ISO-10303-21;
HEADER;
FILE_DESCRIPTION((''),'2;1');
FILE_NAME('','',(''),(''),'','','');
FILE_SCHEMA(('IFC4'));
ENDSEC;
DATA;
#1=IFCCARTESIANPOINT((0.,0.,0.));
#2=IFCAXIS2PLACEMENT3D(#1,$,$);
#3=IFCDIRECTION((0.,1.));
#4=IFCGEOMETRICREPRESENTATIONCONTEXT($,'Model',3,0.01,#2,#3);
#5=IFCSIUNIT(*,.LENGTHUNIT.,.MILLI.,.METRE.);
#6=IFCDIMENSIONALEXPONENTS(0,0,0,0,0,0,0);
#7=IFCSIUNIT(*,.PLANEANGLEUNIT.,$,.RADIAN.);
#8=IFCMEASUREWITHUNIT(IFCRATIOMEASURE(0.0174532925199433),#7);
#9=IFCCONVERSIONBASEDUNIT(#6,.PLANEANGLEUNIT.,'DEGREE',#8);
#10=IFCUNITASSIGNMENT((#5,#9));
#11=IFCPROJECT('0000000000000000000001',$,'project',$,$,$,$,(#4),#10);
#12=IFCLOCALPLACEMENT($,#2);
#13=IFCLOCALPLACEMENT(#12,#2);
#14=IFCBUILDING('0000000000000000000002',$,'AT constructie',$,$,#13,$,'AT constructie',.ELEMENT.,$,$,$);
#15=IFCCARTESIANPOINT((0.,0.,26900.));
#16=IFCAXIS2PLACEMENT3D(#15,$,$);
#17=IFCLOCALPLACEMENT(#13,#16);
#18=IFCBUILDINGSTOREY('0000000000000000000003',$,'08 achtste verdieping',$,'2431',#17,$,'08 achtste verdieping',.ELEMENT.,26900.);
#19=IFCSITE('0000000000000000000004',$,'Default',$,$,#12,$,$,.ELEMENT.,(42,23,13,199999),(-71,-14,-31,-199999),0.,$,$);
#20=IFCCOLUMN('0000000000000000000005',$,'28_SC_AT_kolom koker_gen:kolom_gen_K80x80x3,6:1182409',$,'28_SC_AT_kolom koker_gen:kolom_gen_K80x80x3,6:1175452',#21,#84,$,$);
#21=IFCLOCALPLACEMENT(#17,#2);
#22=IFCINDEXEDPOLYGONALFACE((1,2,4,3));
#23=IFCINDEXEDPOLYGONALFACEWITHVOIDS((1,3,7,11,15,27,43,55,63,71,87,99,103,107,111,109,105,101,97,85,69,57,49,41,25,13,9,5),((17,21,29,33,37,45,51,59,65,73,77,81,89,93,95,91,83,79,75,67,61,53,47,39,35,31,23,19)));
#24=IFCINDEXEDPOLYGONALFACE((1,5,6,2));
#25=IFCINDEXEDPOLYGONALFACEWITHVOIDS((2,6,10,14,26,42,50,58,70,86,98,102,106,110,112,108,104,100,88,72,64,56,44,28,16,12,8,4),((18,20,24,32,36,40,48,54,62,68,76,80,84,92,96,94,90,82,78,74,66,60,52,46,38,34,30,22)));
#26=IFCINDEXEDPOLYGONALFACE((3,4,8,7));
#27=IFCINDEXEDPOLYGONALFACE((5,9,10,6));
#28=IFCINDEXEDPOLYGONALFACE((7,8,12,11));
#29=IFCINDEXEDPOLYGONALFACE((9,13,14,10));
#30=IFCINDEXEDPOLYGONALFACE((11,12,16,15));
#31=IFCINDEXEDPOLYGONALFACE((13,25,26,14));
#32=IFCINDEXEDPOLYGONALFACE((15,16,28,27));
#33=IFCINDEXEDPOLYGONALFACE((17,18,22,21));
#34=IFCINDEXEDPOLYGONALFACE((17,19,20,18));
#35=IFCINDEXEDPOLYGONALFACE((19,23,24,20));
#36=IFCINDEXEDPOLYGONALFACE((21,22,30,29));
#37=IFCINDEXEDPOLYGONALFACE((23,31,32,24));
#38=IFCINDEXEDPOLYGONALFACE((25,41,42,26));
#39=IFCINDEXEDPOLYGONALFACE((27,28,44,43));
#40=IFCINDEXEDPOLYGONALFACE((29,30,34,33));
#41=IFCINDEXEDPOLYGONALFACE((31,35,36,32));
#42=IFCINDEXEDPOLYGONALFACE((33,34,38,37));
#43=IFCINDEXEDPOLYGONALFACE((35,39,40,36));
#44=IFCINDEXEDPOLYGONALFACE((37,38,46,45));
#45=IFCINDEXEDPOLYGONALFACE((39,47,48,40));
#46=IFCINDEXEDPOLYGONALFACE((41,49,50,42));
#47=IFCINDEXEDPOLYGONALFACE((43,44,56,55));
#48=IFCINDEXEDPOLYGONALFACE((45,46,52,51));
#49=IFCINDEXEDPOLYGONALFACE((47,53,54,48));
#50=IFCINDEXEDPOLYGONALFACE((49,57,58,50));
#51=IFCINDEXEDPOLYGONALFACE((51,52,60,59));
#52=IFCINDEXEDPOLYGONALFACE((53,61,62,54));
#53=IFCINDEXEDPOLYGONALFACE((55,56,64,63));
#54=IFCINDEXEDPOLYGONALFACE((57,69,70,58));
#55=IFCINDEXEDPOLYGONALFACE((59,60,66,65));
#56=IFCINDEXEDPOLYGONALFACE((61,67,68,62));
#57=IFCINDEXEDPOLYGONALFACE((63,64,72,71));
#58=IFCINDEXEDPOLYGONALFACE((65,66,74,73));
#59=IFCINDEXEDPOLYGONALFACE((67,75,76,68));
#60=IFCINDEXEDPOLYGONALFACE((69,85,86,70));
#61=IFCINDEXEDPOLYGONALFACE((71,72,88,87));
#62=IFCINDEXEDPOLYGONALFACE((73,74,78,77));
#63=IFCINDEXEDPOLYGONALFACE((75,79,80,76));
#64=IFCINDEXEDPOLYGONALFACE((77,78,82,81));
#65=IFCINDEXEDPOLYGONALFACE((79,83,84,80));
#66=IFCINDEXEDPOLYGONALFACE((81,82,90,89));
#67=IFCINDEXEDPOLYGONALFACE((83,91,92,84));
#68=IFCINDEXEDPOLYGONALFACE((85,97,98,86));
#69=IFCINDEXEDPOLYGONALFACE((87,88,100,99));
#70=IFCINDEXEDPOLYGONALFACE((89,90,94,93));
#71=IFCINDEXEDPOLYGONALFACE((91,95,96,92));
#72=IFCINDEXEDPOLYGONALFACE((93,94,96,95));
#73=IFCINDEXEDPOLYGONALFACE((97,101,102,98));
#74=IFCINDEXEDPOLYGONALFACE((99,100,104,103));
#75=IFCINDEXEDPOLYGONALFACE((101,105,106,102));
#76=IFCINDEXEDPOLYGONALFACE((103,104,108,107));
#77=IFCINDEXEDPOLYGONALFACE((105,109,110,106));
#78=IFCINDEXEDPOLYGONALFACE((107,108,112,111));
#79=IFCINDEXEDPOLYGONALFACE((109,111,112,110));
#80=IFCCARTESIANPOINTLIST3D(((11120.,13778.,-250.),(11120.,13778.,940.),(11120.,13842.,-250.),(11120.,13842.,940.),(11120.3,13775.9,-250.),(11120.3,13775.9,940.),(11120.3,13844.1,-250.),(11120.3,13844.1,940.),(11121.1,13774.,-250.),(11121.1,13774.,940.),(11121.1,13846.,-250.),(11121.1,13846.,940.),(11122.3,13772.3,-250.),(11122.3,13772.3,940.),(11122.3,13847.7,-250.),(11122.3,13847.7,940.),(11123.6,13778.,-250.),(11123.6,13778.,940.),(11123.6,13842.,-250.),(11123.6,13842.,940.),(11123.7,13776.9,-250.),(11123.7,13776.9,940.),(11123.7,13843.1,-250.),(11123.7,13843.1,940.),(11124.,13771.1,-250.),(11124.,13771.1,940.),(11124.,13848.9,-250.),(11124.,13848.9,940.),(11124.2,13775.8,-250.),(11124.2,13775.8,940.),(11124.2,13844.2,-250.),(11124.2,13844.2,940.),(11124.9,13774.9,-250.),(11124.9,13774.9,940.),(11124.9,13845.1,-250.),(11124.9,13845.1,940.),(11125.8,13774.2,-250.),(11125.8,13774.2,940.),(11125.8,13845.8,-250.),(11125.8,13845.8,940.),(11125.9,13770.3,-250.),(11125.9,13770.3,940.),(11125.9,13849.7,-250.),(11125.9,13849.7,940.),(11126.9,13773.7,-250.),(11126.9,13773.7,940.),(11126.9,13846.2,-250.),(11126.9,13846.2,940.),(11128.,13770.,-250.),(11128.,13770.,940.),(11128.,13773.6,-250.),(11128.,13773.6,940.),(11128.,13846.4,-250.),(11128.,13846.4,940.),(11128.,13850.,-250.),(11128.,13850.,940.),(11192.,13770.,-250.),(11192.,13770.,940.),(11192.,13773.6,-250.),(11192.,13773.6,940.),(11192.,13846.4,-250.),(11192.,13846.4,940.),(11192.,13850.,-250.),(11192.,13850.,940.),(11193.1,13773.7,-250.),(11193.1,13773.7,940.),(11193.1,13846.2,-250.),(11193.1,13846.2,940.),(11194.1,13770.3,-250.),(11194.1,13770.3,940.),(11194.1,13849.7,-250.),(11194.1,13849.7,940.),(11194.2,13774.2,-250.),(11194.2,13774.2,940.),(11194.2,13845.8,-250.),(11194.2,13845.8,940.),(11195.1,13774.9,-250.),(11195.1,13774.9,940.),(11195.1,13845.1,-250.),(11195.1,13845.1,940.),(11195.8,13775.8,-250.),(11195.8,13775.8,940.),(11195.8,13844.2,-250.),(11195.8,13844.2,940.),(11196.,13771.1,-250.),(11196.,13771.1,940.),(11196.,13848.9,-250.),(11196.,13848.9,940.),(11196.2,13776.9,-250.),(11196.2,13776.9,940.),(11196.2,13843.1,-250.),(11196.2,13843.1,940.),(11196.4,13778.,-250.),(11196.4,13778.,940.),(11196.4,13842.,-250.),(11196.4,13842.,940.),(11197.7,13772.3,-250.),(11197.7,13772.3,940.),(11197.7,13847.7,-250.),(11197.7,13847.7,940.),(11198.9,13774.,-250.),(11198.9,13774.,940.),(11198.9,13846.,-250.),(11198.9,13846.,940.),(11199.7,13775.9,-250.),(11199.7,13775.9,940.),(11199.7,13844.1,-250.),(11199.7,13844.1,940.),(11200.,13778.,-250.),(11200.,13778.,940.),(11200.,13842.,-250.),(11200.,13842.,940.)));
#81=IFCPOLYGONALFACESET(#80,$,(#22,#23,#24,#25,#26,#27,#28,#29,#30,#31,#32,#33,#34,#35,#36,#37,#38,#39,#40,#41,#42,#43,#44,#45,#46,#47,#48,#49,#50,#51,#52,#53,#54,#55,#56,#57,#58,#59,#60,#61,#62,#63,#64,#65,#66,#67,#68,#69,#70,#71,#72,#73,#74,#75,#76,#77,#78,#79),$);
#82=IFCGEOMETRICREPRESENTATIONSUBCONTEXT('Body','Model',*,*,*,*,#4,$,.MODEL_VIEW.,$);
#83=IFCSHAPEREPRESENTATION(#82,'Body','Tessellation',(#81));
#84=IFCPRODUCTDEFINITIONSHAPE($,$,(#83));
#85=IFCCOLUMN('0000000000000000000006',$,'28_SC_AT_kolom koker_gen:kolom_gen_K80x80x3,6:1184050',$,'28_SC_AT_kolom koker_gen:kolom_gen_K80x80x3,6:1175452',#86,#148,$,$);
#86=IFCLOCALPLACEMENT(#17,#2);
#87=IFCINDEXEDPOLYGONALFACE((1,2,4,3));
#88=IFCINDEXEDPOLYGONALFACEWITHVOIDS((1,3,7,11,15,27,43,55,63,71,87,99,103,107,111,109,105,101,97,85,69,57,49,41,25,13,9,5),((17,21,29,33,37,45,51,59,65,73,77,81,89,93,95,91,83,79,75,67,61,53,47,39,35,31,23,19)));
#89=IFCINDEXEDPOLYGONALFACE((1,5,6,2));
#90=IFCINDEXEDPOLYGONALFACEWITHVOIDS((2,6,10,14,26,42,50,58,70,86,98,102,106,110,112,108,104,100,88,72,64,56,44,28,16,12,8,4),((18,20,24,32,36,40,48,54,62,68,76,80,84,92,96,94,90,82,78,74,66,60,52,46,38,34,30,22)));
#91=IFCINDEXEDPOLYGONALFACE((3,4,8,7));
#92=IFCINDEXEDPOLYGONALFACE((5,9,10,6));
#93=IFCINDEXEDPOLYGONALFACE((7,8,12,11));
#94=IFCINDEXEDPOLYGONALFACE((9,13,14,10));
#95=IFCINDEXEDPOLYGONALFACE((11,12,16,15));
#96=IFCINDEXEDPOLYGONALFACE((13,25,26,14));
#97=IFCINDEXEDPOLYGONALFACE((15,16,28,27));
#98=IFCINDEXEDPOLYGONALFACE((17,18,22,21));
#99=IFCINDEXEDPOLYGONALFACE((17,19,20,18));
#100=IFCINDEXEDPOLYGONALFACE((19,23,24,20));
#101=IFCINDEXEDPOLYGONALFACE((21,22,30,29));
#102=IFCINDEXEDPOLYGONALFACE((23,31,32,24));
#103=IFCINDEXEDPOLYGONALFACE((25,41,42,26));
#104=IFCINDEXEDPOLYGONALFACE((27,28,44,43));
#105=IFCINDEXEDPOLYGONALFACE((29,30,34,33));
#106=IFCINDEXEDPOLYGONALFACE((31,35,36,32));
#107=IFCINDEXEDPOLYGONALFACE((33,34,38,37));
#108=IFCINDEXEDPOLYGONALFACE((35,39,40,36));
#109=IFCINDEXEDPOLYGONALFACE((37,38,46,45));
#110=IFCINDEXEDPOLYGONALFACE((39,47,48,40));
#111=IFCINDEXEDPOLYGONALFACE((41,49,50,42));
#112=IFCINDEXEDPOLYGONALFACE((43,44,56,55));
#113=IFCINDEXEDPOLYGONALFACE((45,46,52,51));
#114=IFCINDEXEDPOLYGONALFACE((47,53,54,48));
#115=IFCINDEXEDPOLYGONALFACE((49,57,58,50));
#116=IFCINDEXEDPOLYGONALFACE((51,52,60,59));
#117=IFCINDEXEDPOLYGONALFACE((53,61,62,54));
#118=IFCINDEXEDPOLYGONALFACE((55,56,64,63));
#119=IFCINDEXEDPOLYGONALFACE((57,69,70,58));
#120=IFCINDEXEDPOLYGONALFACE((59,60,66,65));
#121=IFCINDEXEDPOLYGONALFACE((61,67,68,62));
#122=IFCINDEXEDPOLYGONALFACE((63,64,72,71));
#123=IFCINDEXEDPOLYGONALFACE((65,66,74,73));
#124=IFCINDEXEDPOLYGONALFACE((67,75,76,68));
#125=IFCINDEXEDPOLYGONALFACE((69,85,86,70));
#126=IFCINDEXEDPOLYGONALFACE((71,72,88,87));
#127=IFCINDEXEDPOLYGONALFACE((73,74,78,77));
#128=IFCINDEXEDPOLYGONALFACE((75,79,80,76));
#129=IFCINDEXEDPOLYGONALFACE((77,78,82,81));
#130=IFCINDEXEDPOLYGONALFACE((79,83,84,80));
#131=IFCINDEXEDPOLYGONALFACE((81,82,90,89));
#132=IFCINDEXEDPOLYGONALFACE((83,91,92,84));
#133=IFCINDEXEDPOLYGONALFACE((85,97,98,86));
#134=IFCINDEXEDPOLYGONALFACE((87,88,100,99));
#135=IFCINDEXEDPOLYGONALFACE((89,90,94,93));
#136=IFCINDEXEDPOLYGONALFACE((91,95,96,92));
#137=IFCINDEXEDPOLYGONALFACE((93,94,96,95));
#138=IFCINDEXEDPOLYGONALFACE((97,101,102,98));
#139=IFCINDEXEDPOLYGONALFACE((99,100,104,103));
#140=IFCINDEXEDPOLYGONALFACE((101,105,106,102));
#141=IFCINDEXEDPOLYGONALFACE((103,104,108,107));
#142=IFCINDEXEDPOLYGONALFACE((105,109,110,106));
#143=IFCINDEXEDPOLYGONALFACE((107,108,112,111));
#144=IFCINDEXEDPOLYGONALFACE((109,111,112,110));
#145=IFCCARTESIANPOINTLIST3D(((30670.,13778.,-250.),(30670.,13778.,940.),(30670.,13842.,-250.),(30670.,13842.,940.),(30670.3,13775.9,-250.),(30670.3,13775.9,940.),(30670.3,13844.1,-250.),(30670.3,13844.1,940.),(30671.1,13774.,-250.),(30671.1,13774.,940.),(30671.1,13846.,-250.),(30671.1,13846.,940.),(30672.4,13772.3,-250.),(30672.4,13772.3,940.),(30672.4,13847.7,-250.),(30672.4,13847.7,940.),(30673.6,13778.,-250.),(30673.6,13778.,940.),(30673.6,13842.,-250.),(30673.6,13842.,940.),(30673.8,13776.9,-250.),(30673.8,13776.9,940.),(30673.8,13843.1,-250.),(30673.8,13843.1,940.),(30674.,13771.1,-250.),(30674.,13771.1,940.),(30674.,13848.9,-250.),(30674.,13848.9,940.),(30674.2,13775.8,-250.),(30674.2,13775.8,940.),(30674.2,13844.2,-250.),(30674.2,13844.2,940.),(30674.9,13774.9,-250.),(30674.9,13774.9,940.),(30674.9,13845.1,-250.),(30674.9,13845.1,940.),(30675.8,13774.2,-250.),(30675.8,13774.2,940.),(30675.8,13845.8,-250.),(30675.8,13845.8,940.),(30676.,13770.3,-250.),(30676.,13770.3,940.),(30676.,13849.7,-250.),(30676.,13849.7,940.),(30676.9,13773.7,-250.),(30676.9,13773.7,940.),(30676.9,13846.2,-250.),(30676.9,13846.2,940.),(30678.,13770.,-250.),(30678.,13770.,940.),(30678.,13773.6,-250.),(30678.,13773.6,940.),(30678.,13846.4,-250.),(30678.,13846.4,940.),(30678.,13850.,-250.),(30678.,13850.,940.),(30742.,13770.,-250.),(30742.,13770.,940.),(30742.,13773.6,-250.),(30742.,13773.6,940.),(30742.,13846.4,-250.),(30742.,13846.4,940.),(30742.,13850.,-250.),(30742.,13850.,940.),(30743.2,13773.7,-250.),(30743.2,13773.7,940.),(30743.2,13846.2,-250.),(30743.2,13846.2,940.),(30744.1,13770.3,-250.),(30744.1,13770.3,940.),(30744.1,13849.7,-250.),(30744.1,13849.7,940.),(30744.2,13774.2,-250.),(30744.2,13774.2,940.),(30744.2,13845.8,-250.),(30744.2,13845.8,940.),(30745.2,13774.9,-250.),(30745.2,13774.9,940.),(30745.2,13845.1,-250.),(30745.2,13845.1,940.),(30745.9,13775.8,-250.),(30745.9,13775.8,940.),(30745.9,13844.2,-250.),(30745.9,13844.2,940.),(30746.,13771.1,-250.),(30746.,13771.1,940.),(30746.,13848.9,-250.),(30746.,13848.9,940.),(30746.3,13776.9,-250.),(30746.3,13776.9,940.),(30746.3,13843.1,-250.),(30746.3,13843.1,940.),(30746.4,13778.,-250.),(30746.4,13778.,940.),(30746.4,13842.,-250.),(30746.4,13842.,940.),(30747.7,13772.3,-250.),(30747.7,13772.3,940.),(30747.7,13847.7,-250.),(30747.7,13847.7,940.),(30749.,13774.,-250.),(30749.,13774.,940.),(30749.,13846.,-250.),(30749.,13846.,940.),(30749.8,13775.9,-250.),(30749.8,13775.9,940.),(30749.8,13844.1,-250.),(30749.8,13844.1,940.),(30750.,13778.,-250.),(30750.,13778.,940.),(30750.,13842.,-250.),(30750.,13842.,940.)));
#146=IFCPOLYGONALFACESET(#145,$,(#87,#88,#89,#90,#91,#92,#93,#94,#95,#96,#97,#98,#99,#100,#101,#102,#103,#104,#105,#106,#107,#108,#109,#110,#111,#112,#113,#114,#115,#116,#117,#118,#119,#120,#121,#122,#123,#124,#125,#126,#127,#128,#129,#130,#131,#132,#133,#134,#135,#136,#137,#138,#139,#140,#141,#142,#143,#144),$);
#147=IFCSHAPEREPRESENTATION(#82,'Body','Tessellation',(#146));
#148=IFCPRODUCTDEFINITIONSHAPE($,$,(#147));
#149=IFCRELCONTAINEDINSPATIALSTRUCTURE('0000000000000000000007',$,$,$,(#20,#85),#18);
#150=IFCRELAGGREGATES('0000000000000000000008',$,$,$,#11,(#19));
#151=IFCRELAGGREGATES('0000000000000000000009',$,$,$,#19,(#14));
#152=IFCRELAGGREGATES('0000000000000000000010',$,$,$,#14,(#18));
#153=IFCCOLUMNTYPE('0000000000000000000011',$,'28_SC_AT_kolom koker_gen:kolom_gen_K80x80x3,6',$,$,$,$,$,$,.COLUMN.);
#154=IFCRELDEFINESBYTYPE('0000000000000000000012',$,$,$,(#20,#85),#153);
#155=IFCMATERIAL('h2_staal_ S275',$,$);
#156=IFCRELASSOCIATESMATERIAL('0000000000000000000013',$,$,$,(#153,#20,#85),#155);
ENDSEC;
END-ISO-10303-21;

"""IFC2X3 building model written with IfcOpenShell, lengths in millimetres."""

from ifc_helpers import new_model, entity, si_unit, converted_unit, direction, frame, frame_2d, origin, place, context, subcontext, project, spatial, polyline, circle_curve, parameter, trimmed, segment, composite_curve, outline, extrude, source, transform, mapped, material, type_object, type_shapes, element, save


model = new_model("IFC2X3")

# Units and contexts
model_context = context("Model", 3, precision=0.01, world=origin(), true_north=direction((0.0, 1.0)))
body_context = subcontext(model_context, "Body", "Model", "MODEL_VIEW")
ifc_project = project(units=[si_unit("LENGTHUNIT", "METRE", prefix="MILLI"), converted_unit("PLANEANGLEUNIT", "DEGREE", entity("IfcRatioMeasure", 0.0174532925199433), si_unit("PLANEANGLEUNIT", "RADIAN"), dimensions=[0, 0, 0, 0, 0, 0, 0])], contexts=[model_context])

# Site, building, storey
site_placement = place(None, origin())
site = spatial("IfcSite", under=ifc_project, at=site_placement, Name="Default", CompositionType="ELEMENT", RefLatitude=(42, 23, 13, 199999), RefLongitude=(-71, -14, -31, -199999), RefElevation=0.0)
building_placement = place(site_placement, origin())
building = spatial("IfcBuilding", under=site, at=building_placement, Name="AT constructie", LongName="AT constructie", CompositionType="ELEMENT")
storey_placement = place(building_placement, frame((0.0, 0.0, 26900.0)))
storey = spatial("IfcBuildingStorey", under=building, at=storey_placement, Name="08 achtste verdieping", ObjectType="2431", LongName="08 achtste verdieping", CompositionType="ELEMENT", Elevation=26900.0)

# Columns
ifc_material_1 = material(Name="h2_staal_ S275")
column_type_1 = type_object("IfcColumnType", Name="28_SC_AT_kolom koker_gen:kolom_gen_K80x80x3,6", PredefinedType="COLUMN", material=ifc_material_1)
shared_shape_1 = source(origin(), body_context, "Body", "SweptSolid", [
    extrude(outline(composite_curve([segment(trimmed(circle_curve(frame_2d((32.0, 32.0), x_axis=(1.0, 0.0)), 8.0), [parameter(360.0)], [parameter(90.0)], True, "PARAMETER"), True, "CONTINUOUS"), segment(polyline([(32.0, 40.0), (-32.0, 40.0)]), True, "CONTINUOUS"), segment(trimmed(circle_curve(frame_2d((-32.0, 32.0), x_axis=(1.0, 0.0)), 8.0), [parameter(90.0)], [parameter(180.0)], True, "PARAMETER"), True, "CONTINUOUS"), segment(polyline([(-40.0, 32.0), (-40.0, -32.0)]), True, "CONTINUOUS"), segment(trimmed(circle_curve(frame_2d((-32.0, -32.0), x_axis=(1.0, 0.0)), 8.0), [parameter(180.0)], [parameter(270.0)], True, "PARAMETER"), True, "CONTINUOUS"), segment(polyline([(-32.0, -40.0), (32.0, -40.0)]), True, "CONTINUOUS"), segment(trimmed(circle_curve(frame_2d((32.0, -32.0), x_axis=(1.0, 0.0)), 8.0), [parameter(270.0)], [parameter(0.0)], True, "PARAMETER"), True, "CONTINUOUS"), segment(polyline([(40.0, -32.0), (40.0, 32.0)]), True, "CONTINUOUS")], self_intersect=False), holes=[composite_curve([segment(polyline([(-32.0, 36.4), (32.0, 36.4)]), True, "CONTINUOUS"), segment(trimmed(circle_curve(frame_2d((32.0, 32.0), x_axis=(1.0, 0.0)), 4.4), [parameter(360.0)], [parameter(90.0)], True, "PARAMETER"), False, "CONTINUOUS"), segment(polyline([(36.4, 32.0), (36.4, -32.0)]), True, "CONTINUOUS"), segment(trimmed(circle_curve(frame_2d((32.0, -32.0), x_axis=(1.0, 0.0)), 4.4), [parameter(270.0)], [parameter(360.0)], True, "PARAMETER"), False, "CONTINUOUS"), segment(polyline([(32.0, -36.4), (-32.0, -36.4)]), True, "CONTINUOUS"), segment(trimmed(circle_curve(frame_2d((-32.0, -32.0), x_axis=(1.0, 0.0)), 4.4), [parameter(180.0)], [parameter(270.0)], True, "PARAMETER"), False, "CONTINUOUS"), segment(polyline([(-36.4, -32.0), (-36.4, 32.0)]), True, "CONTINUOUS"), segment(trimmed(circle_curve(frame_2d((-32.0, 32.0), x_axis=(1.0, 0.0)), 4.4), [parameter(90.0)], [parameter(180.0)], True, "PARAMETER"), False, "CONTINUOUS")], self_intersect=False)]), frame((0.0, 0.0, 26650.0), z_axis=(0.0, 0.0, 1.0), x_axis=(-1.0, 0.0, 0.0)), (0.0, 0.0, 1.0), 1190.0),
])
type_shapes(column_type_1, [shared_shape_1])
for number, where, name in (
    (1, (11160.0, 13810.0, -26900.0), "28_SC_AT_kolom koker_gen:kolom_gen_K80x80x3,6:1182409"),
    (2, (30710.0, 13810.0, -26900.0), "28_SC_AT_kolom koker_gen:kolom_gen_K80x80x3,6:1184050"),
):
    element("IfcColumn", number, at=place(storey_placement, frame(where)), inside=storey, type_object=column_type_1, material=ifc_material_1, Name=name, ObjectType="28_SC_AT_kolom koker_gen:kolom_gen_K80x80x3,6:1175452", context=body_context, shape_type="MappedRepresentation", body=[
        mapped(shared_shape_1, transform((0.0, 0.0, 0.0), scale=1.0)),
    ])

save(model, "model.ifc")
